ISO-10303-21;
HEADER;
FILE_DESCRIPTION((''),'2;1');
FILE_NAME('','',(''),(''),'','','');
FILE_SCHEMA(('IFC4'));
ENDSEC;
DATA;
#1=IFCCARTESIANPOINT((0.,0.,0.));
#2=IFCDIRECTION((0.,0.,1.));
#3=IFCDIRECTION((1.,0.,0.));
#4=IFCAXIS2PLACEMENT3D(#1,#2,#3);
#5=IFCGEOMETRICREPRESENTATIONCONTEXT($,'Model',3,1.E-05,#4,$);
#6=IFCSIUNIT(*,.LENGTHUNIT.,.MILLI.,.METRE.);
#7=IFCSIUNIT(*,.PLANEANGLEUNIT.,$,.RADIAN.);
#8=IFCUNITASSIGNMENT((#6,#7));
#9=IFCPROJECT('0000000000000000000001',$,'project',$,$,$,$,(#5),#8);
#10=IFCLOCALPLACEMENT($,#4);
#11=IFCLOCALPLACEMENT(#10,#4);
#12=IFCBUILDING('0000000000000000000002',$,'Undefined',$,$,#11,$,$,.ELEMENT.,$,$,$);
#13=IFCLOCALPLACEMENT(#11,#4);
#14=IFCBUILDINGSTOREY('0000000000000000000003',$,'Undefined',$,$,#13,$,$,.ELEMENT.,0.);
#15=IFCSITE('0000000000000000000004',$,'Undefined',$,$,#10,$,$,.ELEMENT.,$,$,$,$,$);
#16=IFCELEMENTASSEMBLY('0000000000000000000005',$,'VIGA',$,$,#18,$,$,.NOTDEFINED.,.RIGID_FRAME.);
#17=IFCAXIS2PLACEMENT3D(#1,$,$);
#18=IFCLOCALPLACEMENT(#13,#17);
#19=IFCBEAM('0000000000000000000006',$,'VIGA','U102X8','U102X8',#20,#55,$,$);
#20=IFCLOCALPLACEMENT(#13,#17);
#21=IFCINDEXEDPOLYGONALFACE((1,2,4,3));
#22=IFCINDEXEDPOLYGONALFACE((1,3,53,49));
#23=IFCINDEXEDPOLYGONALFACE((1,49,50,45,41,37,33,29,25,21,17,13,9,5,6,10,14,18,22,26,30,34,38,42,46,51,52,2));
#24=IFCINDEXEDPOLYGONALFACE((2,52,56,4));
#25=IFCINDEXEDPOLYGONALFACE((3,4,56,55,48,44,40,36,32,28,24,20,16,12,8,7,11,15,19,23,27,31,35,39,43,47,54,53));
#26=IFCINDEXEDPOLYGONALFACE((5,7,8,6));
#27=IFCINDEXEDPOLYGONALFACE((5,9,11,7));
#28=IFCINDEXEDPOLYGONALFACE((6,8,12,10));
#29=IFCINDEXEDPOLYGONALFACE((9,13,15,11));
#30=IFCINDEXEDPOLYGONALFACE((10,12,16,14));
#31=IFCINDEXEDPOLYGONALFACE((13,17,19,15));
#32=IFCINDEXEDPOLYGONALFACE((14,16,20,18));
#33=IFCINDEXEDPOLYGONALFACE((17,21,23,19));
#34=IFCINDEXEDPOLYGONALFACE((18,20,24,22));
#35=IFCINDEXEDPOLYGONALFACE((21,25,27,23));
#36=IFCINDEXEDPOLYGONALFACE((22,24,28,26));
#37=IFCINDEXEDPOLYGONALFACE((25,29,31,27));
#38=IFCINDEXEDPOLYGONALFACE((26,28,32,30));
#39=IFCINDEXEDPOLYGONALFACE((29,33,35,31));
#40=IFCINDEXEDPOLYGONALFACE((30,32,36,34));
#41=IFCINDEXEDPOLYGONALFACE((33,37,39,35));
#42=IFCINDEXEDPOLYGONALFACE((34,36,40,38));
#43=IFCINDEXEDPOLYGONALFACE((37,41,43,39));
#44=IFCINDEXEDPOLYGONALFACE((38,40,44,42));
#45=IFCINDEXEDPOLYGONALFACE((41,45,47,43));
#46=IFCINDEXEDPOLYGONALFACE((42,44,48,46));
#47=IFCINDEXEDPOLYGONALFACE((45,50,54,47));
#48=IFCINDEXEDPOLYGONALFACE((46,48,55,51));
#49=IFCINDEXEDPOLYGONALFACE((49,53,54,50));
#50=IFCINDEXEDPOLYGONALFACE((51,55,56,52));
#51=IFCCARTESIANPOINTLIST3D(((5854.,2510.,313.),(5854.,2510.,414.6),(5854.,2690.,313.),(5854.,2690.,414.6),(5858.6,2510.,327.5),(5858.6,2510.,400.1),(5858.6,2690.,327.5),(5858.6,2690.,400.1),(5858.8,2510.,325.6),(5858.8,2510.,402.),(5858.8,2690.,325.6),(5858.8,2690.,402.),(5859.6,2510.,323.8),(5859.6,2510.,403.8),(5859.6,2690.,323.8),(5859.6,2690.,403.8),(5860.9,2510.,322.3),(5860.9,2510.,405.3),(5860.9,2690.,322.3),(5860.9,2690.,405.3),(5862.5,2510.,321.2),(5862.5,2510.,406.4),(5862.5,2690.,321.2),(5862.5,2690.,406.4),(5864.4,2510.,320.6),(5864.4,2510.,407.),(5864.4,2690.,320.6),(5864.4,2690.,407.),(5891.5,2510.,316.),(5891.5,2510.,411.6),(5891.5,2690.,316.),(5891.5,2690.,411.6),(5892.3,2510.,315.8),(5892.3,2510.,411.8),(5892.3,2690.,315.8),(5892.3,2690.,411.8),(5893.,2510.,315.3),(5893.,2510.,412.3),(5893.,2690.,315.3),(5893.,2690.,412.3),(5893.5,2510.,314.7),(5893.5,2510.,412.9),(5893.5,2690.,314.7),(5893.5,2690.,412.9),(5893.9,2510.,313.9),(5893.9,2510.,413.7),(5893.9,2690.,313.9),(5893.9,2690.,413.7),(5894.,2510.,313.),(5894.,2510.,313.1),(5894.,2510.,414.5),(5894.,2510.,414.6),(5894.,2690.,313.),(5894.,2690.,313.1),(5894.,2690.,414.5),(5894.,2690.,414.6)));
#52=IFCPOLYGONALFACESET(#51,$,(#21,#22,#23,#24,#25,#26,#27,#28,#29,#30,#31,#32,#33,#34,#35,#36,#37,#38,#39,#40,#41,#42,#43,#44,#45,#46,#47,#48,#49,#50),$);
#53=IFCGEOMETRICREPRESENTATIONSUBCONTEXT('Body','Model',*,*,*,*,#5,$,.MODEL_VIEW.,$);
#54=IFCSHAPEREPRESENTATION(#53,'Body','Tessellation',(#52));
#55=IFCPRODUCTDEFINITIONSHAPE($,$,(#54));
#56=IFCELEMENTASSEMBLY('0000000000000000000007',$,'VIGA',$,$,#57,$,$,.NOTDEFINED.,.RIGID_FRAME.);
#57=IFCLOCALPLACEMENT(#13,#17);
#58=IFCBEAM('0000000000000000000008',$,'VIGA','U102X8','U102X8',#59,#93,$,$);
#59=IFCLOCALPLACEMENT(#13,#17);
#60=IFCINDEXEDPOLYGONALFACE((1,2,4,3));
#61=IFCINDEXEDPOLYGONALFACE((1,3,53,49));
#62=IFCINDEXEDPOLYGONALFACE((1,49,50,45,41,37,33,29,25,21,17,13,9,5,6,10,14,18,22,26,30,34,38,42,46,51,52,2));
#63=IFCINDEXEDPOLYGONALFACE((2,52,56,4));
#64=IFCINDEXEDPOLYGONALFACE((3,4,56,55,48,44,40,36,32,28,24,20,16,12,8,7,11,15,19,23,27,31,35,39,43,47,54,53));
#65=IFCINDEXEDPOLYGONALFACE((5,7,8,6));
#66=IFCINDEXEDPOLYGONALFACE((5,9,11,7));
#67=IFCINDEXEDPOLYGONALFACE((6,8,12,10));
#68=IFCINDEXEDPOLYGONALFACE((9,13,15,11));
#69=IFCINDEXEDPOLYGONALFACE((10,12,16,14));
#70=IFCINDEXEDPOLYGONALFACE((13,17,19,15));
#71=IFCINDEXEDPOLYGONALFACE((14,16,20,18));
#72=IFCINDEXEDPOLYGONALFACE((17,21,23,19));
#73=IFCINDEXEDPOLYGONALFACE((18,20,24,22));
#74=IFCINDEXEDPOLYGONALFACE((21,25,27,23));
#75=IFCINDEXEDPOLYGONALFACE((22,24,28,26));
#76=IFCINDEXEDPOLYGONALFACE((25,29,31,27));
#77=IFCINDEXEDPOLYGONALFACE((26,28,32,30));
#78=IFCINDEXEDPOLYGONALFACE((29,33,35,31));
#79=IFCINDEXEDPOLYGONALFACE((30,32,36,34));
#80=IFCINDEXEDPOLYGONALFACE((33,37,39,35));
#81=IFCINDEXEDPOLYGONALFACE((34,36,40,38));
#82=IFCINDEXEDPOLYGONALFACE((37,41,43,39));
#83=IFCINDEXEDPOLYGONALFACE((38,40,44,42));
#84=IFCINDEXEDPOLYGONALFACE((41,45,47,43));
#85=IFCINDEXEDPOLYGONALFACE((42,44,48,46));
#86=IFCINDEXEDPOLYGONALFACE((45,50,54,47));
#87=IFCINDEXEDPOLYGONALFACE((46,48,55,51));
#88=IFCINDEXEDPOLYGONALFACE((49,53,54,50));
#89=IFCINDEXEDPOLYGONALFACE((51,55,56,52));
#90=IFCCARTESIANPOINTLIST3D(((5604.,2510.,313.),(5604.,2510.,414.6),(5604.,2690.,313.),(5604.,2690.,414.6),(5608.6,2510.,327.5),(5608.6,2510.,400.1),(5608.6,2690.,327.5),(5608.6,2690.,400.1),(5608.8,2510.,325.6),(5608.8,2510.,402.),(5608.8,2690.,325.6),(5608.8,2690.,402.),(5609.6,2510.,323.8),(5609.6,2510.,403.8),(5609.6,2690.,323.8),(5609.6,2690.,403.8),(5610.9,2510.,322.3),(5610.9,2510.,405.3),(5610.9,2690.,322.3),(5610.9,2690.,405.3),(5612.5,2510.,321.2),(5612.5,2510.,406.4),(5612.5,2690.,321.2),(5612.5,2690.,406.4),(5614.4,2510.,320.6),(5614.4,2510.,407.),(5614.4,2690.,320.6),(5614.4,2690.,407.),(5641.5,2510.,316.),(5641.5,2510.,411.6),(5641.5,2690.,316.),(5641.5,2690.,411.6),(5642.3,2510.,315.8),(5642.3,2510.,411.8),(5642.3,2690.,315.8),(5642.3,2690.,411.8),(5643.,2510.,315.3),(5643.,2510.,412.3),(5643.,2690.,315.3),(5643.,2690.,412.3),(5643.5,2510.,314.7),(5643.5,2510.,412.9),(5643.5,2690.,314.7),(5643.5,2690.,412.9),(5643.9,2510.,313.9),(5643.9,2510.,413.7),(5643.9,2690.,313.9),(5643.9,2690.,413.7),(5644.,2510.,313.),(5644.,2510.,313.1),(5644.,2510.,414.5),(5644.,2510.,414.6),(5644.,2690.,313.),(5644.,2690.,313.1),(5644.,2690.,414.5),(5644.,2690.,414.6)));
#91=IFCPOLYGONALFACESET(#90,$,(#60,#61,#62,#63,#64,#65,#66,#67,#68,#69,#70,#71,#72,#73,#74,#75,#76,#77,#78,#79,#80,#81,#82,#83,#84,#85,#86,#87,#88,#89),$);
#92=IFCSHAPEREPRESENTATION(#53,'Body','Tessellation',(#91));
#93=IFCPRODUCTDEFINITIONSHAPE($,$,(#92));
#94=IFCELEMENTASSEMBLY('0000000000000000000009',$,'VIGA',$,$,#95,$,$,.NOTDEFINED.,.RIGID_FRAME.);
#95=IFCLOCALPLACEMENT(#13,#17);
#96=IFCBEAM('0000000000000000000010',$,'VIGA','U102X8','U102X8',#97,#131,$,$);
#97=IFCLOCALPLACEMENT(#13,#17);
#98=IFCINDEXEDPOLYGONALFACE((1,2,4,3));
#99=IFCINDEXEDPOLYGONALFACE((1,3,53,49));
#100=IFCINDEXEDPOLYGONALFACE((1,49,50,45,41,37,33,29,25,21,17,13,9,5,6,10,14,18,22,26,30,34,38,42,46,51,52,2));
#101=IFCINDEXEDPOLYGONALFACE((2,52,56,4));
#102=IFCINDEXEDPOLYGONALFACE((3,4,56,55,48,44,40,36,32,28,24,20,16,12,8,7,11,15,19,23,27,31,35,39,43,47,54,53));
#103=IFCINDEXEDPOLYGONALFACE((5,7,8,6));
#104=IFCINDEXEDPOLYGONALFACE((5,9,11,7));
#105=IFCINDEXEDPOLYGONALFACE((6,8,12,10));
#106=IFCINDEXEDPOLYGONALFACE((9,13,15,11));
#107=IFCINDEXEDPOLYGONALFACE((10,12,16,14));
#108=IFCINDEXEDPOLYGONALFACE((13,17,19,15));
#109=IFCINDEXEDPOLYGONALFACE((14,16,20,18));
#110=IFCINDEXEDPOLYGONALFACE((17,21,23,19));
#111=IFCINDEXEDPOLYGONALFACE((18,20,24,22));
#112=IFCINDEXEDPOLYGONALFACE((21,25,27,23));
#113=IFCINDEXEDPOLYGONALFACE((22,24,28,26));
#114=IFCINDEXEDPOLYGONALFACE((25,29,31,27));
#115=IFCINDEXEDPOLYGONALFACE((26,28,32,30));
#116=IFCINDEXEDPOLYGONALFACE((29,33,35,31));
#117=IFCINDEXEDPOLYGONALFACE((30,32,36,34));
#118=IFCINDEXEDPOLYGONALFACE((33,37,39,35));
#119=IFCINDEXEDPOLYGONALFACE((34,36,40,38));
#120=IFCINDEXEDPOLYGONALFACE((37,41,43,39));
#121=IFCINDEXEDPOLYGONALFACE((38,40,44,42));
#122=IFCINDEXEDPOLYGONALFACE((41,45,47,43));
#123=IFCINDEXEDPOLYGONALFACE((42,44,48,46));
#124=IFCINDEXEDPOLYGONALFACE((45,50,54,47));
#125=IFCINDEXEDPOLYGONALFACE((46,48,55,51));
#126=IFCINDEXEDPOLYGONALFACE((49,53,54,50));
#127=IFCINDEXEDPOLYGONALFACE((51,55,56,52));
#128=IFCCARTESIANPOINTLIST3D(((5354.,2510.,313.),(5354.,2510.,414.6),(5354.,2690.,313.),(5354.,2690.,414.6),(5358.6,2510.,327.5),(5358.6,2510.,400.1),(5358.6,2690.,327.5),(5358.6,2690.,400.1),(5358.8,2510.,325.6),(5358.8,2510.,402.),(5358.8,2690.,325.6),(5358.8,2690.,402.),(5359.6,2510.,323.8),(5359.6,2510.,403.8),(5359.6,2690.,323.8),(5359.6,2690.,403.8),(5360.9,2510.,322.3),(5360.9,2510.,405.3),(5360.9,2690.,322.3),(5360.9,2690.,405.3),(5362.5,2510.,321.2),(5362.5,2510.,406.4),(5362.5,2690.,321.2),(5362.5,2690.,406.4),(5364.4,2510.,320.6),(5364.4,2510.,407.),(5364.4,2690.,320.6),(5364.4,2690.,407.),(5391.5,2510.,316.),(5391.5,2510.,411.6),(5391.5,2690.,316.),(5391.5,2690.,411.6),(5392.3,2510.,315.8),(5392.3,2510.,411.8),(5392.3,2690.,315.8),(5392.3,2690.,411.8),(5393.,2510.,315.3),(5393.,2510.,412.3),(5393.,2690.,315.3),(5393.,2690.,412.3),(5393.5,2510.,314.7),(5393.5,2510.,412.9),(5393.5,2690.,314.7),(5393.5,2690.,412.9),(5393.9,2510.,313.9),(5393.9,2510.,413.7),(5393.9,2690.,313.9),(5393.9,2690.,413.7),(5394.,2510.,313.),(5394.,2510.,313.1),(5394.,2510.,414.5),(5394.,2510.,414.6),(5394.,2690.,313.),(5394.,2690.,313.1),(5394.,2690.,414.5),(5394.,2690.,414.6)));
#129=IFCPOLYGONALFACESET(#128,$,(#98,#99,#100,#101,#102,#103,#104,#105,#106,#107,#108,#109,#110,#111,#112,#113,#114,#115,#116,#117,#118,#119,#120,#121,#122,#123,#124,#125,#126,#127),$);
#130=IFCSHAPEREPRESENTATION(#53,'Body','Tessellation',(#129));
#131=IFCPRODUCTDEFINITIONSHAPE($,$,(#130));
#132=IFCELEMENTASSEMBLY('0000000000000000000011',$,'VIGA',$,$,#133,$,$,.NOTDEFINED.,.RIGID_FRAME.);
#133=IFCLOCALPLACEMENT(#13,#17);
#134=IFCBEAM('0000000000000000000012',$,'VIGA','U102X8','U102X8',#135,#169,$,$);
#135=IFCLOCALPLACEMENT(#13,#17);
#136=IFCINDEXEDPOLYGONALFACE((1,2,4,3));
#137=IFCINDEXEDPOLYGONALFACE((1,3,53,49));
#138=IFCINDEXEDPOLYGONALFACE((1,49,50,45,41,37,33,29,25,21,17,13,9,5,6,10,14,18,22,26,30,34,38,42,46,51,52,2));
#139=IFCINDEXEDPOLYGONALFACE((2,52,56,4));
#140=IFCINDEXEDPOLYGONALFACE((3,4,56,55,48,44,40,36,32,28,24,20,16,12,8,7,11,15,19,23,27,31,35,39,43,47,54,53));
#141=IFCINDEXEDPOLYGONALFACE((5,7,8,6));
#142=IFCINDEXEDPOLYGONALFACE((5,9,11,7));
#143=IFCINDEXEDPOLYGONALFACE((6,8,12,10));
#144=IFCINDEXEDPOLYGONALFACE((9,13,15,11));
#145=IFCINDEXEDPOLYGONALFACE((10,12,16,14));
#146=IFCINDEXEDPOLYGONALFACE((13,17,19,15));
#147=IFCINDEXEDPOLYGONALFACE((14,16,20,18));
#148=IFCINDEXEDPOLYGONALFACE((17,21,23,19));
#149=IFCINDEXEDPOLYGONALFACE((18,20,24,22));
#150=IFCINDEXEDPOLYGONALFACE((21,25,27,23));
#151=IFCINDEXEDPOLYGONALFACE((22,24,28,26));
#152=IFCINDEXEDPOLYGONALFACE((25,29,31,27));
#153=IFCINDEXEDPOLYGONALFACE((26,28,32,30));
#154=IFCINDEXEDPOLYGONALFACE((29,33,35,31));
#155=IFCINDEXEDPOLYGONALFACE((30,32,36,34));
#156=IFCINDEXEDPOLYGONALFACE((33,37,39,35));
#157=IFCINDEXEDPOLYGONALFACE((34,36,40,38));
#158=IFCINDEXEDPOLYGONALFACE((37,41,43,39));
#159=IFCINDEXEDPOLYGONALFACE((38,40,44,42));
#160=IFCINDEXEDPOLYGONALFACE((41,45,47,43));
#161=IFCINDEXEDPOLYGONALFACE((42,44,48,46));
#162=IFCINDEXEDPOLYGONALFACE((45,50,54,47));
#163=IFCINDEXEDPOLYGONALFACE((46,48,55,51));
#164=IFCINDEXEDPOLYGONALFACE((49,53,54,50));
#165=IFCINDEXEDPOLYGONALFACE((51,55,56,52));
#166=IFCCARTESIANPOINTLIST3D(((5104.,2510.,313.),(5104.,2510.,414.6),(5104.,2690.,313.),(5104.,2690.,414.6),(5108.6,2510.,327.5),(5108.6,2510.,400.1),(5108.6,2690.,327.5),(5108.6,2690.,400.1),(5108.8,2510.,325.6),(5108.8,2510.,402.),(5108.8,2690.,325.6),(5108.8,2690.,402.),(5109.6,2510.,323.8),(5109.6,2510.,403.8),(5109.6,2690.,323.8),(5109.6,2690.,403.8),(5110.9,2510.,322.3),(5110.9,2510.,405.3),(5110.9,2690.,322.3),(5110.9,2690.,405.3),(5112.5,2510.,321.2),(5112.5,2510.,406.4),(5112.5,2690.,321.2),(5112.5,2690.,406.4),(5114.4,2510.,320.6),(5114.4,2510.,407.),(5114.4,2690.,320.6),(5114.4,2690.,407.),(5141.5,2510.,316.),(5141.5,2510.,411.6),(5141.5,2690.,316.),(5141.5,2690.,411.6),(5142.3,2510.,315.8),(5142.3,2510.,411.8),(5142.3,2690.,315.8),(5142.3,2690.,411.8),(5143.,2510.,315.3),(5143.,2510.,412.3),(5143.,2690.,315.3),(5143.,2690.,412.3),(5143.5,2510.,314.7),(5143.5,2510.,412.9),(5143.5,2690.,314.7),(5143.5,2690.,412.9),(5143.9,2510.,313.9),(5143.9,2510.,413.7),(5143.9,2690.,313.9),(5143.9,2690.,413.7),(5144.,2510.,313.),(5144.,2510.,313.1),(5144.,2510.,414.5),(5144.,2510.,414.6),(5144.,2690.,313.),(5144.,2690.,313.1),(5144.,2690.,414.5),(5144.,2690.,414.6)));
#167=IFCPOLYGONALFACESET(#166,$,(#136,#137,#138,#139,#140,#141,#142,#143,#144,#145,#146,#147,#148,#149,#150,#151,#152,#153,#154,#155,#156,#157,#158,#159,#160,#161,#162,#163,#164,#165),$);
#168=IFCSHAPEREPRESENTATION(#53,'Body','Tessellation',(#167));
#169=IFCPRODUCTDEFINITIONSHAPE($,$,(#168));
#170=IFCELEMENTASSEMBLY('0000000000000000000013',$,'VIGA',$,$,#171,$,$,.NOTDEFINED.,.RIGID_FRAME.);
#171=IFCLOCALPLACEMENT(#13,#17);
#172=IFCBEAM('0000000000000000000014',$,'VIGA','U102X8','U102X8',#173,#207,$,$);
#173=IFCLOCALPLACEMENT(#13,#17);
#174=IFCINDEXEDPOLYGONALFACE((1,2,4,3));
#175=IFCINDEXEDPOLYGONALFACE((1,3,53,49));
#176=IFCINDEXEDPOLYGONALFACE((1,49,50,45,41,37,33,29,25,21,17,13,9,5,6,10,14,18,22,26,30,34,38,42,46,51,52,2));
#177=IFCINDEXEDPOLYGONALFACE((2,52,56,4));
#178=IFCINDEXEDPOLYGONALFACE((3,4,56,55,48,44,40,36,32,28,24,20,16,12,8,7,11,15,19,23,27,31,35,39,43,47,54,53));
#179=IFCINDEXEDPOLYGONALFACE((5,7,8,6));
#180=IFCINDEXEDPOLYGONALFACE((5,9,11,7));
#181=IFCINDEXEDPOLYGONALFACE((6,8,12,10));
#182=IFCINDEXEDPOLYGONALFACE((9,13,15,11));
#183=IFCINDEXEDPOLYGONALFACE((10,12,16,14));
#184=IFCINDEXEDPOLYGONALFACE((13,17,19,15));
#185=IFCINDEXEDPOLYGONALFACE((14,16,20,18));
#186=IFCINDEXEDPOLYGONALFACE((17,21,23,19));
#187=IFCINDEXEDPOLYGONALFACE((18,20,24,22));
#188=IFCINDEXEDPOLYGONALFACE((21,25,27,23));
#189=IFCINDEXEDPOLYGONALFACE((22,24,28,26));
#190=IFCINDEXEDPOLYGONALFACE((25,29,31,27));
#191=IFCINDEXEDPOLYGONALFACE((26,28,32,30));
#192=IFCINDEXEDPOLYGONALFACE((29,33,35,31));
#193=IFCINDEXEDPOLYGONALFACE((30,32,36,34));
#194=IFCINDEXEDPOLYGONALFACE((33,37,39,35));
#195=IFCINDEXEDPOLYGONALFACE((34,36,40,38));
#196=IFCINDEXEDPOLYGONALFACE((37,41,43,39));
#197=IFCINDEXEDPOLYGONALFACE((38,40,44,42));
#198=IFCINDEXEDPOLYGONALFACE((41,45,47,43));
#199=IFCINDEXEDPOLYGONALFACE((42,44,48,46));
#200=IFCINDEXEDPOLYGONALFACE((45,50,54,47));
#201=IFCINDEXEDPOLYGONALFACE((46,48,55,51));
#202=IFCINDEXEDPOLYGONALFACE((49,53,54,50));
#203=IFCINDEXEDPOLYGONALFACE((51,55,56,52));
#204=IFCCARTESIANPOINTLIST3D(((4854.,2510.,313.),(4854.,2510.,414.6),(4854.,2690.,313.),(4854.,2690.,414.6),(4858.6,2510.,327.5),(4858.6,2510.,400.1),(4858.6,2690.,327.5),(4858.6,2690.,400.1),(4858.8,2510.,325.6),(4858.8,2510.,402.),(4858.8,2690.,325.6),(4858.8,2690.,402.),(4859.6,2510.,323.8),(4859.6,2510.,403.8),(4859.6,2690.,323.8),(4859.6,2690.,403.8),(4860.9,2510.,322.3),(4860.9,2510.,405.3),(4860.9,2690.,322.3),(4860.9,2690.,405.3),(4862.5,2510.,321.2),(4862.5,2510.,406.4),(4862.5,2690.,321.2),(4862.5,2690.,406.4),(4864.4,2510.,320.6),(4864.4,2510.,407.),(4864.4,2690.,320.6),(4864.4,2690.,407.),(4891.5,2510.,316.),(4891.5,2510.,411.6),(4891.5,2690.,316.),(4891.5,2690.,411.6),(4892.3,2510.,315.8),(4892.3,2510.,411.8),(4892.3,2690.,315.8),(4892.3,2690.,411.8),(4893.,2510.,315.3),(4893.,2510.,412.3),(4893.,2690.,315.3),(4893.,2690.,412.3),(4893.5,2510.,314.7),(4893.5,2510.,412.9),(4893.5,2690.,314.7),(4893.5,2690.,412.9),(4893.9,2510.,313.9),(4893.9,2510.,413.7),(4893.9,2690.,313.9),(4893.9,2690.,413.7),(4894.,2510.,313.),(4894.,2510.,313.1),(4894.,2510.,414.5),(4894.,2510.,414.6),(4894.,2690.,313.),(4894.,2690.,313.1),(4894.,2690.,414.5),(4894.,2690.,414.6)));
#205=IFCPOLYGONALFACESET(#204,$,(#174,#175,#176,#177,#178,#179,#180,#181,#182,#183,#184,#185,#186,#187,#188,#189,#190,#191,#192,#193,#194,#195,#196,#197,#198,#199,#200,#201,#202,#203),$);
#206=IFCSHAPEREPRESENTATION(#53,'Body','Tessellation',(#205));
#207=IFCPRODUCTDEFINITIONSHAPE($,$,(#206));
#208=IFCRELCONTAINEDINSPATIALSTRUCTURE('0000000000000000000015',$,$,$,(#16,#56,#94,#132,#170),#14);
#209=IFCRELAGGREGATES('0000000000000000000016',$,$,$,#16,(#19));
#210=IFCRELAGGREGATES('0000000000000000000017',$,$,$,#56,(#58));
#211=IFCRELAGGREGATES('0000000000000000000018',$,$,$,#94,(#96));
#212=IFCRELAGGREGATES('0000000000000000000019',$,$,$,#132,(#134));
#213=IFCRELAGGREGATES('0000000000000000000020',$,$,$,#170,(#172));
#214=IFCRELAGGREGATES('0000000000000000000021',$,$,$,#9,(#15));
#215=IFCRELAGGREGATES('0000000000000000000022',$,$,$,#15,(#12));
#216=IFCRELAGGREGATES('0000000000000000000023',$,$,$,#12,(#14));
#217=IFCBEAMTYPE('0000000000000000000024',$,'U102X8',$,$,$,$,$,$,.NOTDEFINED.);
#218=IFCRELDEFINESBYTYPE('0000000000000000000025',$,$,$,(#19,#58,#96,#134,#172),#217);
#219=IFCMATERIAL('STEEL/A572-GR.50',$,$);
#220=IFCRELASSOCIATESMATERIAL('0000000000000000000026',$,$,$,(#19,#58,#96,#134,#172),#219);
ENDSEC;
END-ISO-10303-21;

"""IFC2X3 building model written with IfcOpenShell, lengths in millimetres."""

from ifc_helpers import new_model, si_unit, frame, origin_with_axes, origin_2d_with_axis, place, context, subcontext, project, spatial, u_section, extrude, material, type_object, element, aggregate, save


model = new_model("IFC2X3")

# Units and contexts
model_context = context("Model", 3, precision=1e-05, world=origin_with_axes())
body_context = subcontext(model_context, "Body", "Model", "MODEL_VIEW")
ifc_project = project(units=[si_unit("LENGTHUNIT", "METRE", prefix="MILLI"), si_unit("PLANEANGLEUNIT", "RADIAN")], contexts=[model_context])

# Site, building, storey
site_placement = place(None, origin_with_axes())
site = spatial("IfcSite", under=ifc_project, at=site_placement, Name="Undefined", CompositionType="ELEMENT")
building_placement = place(site_placement, origin_with_axes())
building = spatial("IfcBuilding", under=site, at=building_placement, Name="Undefined", CompositionType="ELEMENT")
storey_placement = place(building_placement, origin_with_axes())
storey = spatial("IfcBuildingStorey", under=building, at=storey_placement, Name="Undefined", CompositionType="ELEMENT", Elevation=0.0)

# Element assemblies, beams
ifc_material = material(Name="STEEL/A572-GR.50")
beam_type = type_object("IfcBeamType", Name="U102X8", PredefinedType="NOTDEFINED")
assembly_1_placement = place(storey_placement, origin_with_axes())
assembly_1 = element("IfcElementAssembly", 1, at=assembly_1_placement, inside=storey, Name="VIGA", AssemblyPlace="NOTDEFINED", PredefinedType="RIGID_FRAME")
beam_1_placement = place(assembly_1_placement, frame((5874.0, 2510.0, 363.8), z_axis=(0.0, 0.0, 1.0), x_axis=(0.0, 1.0, 0.0)))
beam_1 = element("IfcBeam", 2, at=beam_1_placement, type_object=beam_type, material=ifc_material, Name="VIGA", Description="U102X8", ObjectType="U102X8", context=body_context, shape_type="SweptSolid", body=[
    extrude(u_section(Depth=101.6, FlangeWidth=40.0, WebThickness=4.6, FlangeThickness=6.0, FilletRadius=7.0, EdgeRadius=3.0, FlangeSlope=0.16839, at=origin_2d_with_axis()), frame((180.0, 0.0, 0.0), z_axis=(-1.0, 0.0, 0.0), x_axis=(0.0, -1.0, 0.0)), (0.0, 0.0, 1.0), 180.0),
])
aggregate(assembly_1, [beam_1])
assembly_2_placement = place(storey_placement, origin_with_axes())
assembly_2 = element("IfcElementAssembly", 3, at=assembly_2_placement, inside=storey, Name="VIGA", AssemblyPlace="NOTDEFINED", PredefinedType="RIGID_FRAME")
beam_2_placement = place(assembly_2_placement, frame((5624.0, 2510.0, 363.8), z_axis=(0.0, 0.0, 1.0), x_axis=(0.0, 1.0, 0.0)))
beam_2 = element("IfcBeam", 4, at=beam_2_placement, type_object=beam_type, material=ifc_material, Name="VIGA", Description="U102X8", ObjectType="U102X8", context=body_context, shape_type="SweptSolid", body=[
    extrude(u_section(Depth=101.6, FlangeWidth=40.0, WebThickness=4.6, FlangeThickness=6.0, FilletRadius=7.0, EdgeRadius=3.0, FlangeSlope=0.16839, at=origin_2d_with_axis()), frame((180.0, 0.0, 0.0), z_axis=(-1.0, 0.0, 0.0), x_axis=(0.0, -1.0, 0.0)), (0.0, 0.0, 1.0), 180.0),
])
aggregate(assembly_2, [beam_2])
assembly_3_placement = place(storey_placement, origin_with_axes())
assembly_3 = element("IfcElementAssembly", 5, at=assembly_3_placement, inside=storey, Name="VIGA", AssemblyPlace="NOTDEFINED", PredefinedType="RIGID_FRAME")
beam_3_placement = place(assembly_3_placement, frame((5374.0, 2510.0, 363.8), z_axis=(0.0, 0.0, 1.0), x_axis=(0.0, 1.0, 0.0)))
beam_3 = element("IfcBeam", 6, at=beam_3_placement, type_object=beam_type, material=ifc_material, Name="VIGA", Description="U102X8", ObjectType="U102X8", context=body_context, shape_type="SweptSolid", body=[
    extrude(u_section(Depth=101.6, FlangeWidth=40.0, WebThickness=4.6, FlangeThickness=6.0, FilletRadius=7.0, EdgeRadius=3.0, FlangeSlope=0.16839, at=origin_2d_with_axis()), frame((180.0, 0.0, 0.0), z_axis=(-1.0, 0.0, 0.0), x_axis=(0.0, -1.0, 0.0)), (0.0, 0.0, 1.0), 180.0),
])
aggregate(assembly_3, [beam_3])
assembly_4_placement = place(storey_placement, origin_with_axes())
assembly_4 = element("IfcElementAssembly", 7, at=assembly_4_placement, inside=storey, Name="VIGA", AssemblyPlace="NOTDEFINED", PredefinedType="RIGID_FRAME")
beam_4_placement = place(assembly_4_placement, frame((5124.0, 2510.0, 363.8), z_axis=(0.0, 0.0, 1.0), x_axis=(0.0, 1.0, 0.0)))
beam_4 = element("IfcBeam", 8, at=beam_4_placement, type_object=beam_type, material=ifc_material, Name="VIGA", Description="U102X8", ObjectType="U102X8", context=body_context, shape_type="SweptSolid", body=[
    extrude(u_section(Depth=101.6, FlangeWidth=40.0, WebThickness=4.6, FlangeThickness=6.0, FilletRadius=7.0, EdgeRadius=3.0, FlangeSlope=0.16839, at=origin_2d_with_axis()), frame((180.0, 0.0, 0.0), z_axis=(-1.0, 0.0, 0.0), x_axis=(0.0, -1.0, 0.0)), (0.0, 0.0, 1.0), 180.0),
])
aggregate(assembly_4, [beam_4])
assembly_5_placement = place(storey_placement, origin_with_axes())
assembly_5 = element("IfcElementAssembly", 9, at=assembly_5_placement, inside=storey, Name="VIGA", AssemblyPlace="NOTDEFINED", PredefinedType="RIGID_FRAME")
beam_5_placement = place(assembly_5_placement, frame((4874.0, 2510.0, 363.8), z_axis=(0.0, 0.0, 1.0), x_axis=(0.0, 1.0, 0.0)))
beam_5 = element("IfcBeam", 10, at=beam_5_placement, type_object=beam_type, material=ifc_material, Name="VIGA", Description="U102X8", ObjectType="U102X8", context=body_context, shape_type="SweptSolid", body=[
    extrude(u_section(Depth=101.6, FlangeWidth=40.0, WebThickness=4.6, FlangeThickness=6.0, FilletRadius=7.0, EdgeRadius=3.0, FlangeSlope=0.16839, at=origin_2d_with_axis()), frame((180.0, 0.0, 0.0), z_axis=(-1.0, 0.0, 0.0), x_axis=(0.0, -1.0, 0.0)), (0.0, 0.0, 1.0), 180.0),
])
aggregate(assembly_5, [beam_5])

save(model, "model.ifc")
